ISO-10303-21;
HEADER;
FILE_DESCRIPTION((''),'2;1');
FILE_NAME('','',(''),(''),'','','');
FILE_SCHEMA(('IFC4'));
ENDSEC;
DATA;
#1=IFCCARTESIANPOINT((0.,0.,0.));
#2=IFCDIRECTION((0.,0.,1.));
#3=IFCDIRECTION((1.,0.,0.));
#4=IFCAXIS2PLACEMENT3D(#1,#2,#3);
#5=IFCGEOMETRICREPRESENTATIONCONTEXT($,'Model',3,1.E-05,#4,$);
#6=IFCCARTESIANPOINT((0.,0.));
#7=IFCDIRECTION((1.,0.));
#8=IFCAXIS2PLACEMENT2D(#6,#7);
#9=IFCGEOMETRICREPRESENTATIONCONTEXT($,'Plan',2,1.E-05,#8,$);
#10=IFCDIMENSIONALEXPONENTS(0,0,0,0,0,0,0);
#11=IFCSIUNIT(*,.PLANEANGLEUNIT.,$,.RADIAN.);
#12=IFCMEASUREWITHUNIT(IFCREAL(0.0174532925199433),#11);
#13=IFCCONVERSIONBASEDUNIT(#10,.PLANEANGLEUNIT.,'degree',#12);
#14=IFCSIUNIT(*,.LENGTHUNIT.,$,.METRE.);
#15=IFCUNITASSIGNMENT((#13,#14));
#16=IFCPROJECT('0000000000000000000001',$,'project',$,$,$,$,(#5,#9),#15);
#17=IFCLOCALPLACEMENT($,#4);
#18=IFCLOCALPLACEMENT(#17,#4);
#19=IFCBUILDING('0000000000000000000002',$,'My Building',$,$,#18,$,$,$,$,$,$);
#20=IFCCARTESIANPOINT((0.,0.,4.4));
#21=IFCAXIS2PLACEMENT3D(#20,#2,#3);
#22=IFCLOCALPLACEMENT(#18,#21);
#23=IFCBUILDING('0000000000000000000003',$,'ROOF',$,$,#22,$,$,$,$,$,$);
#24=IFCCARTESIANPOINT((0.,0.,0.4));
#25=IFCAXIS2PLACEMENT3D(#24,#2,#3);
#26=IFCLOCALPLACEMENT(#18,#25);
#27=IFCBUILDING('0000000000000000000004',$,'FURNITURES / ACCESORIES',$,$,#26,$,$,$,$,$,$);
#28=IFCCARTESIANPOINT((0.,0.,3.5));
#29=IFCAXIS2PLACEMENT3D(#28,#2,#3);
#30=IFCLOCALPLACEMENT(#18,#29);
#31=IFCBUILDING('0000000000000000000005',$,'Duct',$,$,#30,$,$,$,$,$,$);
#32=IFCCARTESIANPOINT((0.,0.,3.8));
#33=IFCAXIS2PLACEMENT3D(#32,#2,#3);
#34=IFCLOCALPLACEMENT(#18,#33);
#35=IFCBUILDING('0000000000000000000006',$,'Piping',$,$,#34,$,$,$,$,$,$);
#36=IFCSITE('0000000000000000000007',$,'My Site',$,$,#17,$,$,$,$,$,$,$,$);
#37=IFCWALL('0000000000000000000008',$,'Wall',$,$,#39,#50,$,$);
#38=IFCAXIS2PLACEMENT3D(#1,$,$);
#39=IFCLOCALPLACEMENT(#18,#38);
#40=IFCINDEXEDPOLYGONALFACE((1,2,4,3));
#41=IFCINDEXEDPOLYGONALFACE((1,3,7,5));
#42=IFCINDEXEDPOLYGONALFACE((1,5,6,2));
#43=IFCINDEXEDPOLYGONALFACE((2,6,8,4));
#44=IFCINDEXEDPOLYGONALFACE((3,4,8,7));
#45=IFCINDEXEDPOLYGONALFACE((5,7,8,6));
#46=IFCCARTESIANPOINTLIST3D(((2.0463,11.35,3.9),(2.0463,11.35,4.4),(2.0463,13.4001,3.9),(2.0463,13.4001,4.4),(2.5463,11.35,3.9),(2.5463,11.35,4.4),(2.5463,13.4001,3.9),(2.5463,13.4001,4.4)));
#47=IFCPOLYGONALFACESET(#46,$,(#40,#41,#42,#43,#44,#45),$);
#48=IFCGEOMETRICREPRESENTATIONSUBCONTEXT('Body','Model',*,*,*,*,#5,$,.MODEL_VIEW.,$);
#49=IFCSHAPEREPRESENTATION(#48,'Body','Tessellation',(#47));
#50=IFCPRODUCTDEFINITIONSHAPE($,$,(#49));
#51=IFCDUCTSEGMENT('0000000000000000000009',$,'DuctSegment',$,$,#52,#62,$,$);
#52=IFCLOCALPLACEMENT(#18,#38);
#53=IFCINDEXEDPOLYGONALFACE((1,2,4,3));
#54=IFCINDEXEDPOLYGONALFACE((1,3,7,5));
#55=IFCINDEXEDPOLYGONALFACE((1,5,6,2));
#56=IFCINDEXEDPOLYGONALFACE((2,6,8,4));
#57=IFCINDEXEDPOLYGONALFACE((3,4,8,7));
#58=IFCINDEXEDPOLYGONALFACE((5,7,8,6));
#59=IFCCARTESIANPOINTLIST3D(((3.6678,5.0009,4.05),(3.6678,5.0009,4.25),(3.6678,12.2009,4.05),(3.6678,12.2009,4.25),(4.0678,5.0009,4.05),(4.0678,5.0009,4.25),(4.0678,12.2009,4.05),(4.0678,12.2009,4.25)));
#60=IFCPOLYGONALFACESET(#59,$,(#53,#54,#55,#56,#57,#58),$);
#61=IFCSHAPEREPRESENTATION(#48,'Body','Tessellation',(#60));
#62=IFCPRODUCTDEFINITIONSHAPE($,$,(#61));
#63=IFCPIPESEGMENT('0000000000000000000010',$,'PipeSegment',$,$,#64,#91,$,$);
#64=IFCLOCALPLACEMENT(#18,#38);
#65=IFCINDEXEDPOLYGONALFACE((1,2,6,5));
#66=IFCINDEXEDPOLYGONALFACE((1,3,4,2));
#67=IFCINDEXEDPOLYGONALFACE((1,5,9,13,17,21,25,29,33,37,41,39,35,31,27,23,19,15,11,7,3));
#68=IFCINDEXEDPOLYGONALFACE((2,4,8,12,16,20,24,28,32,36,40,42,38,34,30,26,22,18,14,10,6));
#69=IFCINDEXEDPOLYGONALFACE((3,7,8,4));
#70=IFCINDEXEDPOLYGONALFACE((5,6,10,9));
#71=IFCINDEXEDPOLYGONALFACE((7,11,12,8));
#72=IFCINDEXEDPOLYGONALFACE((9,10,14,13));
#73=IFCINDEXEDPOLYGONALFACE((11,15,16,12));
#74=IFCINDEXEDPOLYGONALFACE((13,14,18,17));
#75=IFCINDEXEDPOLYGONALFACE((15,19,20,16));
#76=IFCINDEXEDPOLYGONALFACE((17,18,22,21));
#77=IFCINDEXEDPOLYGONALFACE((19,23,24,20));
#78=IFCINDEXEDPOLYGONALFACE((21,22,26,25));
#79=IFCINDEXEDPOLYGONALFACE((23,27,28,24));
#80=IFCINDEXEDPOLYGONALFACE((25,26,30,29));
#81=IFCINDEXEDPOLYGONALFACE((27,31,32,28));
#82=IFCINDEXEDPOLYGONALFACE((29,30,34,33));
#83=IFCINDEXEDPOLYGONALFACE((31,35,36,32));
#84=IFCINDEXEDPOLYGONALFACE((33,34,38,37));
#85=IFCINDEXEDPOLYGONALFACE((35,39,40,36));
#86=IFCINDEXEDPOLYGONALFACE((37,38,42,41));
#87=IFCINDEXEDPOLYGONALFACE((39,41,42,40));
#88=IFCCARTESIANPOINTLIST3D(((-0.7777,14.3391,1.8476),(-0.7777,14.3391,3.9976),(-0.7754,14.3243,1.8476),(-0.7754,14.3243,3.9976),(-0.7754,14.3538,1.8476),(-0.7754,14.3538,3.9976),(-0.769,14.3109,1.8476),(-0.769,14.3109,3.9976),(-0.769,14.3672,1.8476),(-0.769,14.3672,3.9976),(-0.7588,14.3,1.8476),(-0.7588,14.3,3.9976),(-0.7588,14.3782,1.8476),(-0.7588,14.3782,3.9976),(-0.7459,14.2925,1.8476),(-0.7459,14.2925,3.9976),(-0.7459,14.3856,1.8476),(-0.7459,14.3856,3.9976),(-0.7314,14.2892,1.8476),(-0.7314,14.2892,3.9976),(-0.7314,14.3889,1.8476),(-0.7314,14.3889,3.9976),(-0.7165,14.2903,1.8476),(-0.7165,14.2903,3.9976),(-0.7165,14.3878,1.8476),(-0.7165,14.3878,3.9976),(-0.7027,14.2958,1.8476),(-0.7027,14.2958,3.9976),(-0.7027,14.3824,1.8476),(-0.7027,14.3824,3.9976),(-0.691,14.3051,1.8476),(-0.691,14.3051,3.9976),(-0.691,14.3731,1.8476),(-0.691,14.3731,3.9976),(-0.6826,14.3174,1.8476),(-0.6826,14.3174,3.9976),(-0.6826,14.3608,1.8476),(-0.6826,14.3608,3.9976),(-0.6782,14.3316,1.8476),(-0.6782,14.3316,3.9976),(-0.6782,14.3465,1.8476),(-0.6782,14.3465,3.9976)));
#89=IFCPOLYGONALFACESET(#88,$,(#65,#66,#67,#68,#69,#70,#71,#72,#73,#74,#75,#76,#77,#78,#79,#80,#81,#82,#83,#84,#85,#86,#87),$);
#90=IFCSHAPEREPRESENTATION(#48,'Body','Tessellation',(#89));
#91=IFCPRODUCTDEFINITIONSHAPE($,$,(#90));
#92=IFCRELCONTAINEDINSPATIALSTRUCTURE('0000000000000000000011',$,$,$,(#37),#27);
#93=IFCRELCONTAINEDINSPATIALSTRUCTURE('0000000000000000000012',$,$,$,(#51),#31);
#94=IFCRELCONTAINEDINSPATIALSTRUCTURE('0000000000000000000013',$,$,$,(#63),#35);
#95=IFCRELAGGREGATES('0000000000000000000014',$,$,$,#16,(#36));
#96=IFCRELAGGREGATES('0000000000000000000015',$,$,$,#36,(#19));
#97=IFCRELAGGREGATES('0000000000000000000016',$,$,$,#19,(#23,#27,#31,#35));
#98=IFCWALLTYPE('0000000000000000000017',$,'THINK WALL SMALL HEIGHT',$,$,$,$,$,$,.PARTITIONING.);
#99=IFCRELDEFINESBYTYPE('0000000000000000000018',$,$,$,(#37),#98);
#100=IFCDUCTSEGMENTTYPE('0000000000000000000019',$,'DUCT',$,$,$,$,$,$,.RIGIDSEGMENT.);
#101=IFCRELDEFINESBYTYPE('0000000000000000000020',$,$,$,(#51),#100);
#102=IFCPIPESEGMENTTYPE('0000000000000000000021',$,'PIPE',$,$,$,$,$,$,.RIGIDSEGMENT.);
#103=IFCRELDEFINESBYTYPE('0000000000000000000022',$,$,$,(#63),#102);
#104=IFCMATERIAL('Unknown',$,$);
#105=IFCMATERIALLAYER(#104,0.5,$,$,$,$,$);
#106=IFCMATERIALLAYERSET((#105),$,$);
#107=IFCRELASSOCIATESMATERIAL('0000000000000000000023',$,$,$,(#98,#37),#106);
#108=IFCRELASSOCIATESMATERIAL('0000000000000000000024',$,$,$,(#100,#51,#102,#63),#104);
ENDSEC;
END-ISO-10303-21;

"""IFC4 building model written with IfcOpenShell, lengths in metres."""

from ifc_helpers import new_model, entity, si_unit, converted_unit, frame, origin_with_axes, origin_2d_with_axis, place, context, subcontext, project, spatial, line, indexed_curve, rectangle, circle, outline, extrude, material, layer, layer_set, layer_usage, material_profile, profile_set, profile_usage, type_object, element, save


model = new_model("IFC4")

# Units and contexts
model_context = context("Model", 3, precision=1e-05, world=origin_with_axes())
plan_context = context("Plan", 2, precision=1e-05, world=origin_2d_with_axis())
body_context_1 = subcontext(model_context, "Body", "Model", "MODEL_VIEW")
ifc_project = project(units=[converted_unit("PLANEANGLEUNIT", "degree", entity("IfcReal", 0.0174532925199433), si_unit("PLANEANGLEUNIT", "RADIAN"), dimensions=[0, 0, 0, 0, 0, 0, 0]), si_unit("LENGTHUNIT", "METRE")], contexts=[model_context, plan_context])

# Site, building
site_placement = place(None, origin_with_axes())
site = spatial("IfcSite", under=ifc_project, at=site_placement, Name="My Site")
building_1_placement = place(site_placement, origin_with_axes())
building_1 = spatial("IfcBuilding", under=site, at=building_1_placement, Name="My Building")

# Shared definitions
ifc_material = material(Name="Unknown")

# Shared definitions
building_2_placement = place(building_1_placement, frame((0.0, 0.0, 4.4), z_axis=(0.0, 0.0, 1.0), x_axis=(1.0, 0.0, 0.0)))
building_2 = spatial("IfcBuilding", under=building_1, at=building_2_placement, Name="ROOF")

# Shared definitions
building_3_placement = place(building_1_placement, frame((0.0, 0.0, 0.4), z_axis=(0.0, 0.0, 1.0), x_axis=(1.0, 0.0, 0.0)))
building_3 = spatial("IfcBuilding", under=building_1, at=building_3_placement, Name="FURNITURES / ACCESORIES")

# Wall
ifc_layer_1 = layer(ifc_material, 0.5)
ifc_layer_set_1 = layer_set([ifc_layer_1])
ifc_layer_usage_1 = layer_usage(ifc_layer_set_1, "AXIS2", "POSITIVE", 0.0)
wall_type_1 = type_object("IfcWallType", Name="THINK WALL SMALL HEIGHT", PredefinedType="PARTITIONING", material=ifc_layer_set_1)
wall_1_placement = place(building_3_placement, frame((2.5463, 11.35, 3.5), z_axis=(0.0, 0.0, 1.0), x_axis=(0.000008, 1.0, 0.0)))
element("IfcWall", 1, at=wall_1_placement, inside=building_3, type_object=wall_type_1, material=ifc_layer_usage_1, Name="Wall", context=body_context_1, shape_type="SweptSolid", body=[
    extrude(outline(indexed_curve([(0.0, 0.0), (0.0, 0.5), (2.0501, 0.5), (2.0501, 0.0)], segments=[line(1, 2, 3, 4, 1)])), origin_with_axes(), (0.0, 0.0, 1.0), 0.5),
])

# Shared definitions
building_4_placement = place(building_1_placement, frame((0.0, 0.0, 3.5), z_axis=(0.0, 0.0, 1.0), x_axis=(1.0, 0.0, 0.0)))
building_4 = spatial("IfcBuilding", under=building_1, at=building_4_placement, Name="Duct")

# Duct segment
ifc_material_profile_1 = material_profile(ifc_material, rectangle(XDim=0.4, YDim=0.2))
ifc_profile_set_1 = profile_set([ifc_material_profile_1])
ifc_profile_usage_1 = profile_usage(ifc_profile_set_1, cardinal=5)
duct_segment_type = type_object("IfcDuctSegmentType", Name="DUCT", PredefinedType="RIGIDSEGMENT", material=ifc_profile_set_1)
duct_segment_placement = place(building_4_placement, frame((3.8678, 12.2009, 0.65), z_axis=(0.0, -1.0, 0.0), x_axis=(1.0, 0.0, 0.0)))
element("IfcDuctSegment", 2, at=duct_segment_placement, inside=building_4, type_object=duct_segment_type, material=ifc_profile_usage_1, Name="DuctSegment", context=body_context_1, shape_type="SweptSolid", body=[
    extrude(rectangle(XDim=0.4, YDim=0.2), origin_with_axes(), (0.0, 0.0, 1.0), 7.2),
])

# Shared definitions
building_5_placement = place(building_1_placement, frame((0.0, 0.0, 3.8), z_axis=(0.0, 0.0, 1.0), x_axis=(1.0, 0.0, 0.0)))
building_5 = spatial("IfcBuilding", under=building_1, at=building_5_placement, Name="Piping")

# Pipe segment
ifc_material_profile_2 = material_profile(ifc_material, circle(Radius=0.05))
ifc_profile_set_2 = profile_set([ifc_material_profile_2])
ifc_profile_usage_2 = profile_usage(ifc_profile_set_2, cardinal=5)
pipe_segment_type = type_object("IfcPipeSegmentType", Name="PIPE", PredefinedType="RIGIDSEGMENT", material=ifc_profile_set_2)
pipe_segment_1_placement = place(building_5_placement, frame((-0.7277, 14.3391, -1.9524), z_axis=(0.0, 0.0, 1.0), x_axis=(-1.0, 0.0, 0.0)))
element("IfcPipeSegment", 3, at=pipe_segment_1_placement, inside=building_5, type_object=pipe_segment_type, material=ifc_profile_usage_2, Name="PipeSegment", context=body_context_1, shape_type="SweptSolid", body=[
    extrude(circle(Radius=0.05), origin_with_axes(), (0.0, 0.0, 1.0), 2.15),
])

save(model, "model.ifc")
